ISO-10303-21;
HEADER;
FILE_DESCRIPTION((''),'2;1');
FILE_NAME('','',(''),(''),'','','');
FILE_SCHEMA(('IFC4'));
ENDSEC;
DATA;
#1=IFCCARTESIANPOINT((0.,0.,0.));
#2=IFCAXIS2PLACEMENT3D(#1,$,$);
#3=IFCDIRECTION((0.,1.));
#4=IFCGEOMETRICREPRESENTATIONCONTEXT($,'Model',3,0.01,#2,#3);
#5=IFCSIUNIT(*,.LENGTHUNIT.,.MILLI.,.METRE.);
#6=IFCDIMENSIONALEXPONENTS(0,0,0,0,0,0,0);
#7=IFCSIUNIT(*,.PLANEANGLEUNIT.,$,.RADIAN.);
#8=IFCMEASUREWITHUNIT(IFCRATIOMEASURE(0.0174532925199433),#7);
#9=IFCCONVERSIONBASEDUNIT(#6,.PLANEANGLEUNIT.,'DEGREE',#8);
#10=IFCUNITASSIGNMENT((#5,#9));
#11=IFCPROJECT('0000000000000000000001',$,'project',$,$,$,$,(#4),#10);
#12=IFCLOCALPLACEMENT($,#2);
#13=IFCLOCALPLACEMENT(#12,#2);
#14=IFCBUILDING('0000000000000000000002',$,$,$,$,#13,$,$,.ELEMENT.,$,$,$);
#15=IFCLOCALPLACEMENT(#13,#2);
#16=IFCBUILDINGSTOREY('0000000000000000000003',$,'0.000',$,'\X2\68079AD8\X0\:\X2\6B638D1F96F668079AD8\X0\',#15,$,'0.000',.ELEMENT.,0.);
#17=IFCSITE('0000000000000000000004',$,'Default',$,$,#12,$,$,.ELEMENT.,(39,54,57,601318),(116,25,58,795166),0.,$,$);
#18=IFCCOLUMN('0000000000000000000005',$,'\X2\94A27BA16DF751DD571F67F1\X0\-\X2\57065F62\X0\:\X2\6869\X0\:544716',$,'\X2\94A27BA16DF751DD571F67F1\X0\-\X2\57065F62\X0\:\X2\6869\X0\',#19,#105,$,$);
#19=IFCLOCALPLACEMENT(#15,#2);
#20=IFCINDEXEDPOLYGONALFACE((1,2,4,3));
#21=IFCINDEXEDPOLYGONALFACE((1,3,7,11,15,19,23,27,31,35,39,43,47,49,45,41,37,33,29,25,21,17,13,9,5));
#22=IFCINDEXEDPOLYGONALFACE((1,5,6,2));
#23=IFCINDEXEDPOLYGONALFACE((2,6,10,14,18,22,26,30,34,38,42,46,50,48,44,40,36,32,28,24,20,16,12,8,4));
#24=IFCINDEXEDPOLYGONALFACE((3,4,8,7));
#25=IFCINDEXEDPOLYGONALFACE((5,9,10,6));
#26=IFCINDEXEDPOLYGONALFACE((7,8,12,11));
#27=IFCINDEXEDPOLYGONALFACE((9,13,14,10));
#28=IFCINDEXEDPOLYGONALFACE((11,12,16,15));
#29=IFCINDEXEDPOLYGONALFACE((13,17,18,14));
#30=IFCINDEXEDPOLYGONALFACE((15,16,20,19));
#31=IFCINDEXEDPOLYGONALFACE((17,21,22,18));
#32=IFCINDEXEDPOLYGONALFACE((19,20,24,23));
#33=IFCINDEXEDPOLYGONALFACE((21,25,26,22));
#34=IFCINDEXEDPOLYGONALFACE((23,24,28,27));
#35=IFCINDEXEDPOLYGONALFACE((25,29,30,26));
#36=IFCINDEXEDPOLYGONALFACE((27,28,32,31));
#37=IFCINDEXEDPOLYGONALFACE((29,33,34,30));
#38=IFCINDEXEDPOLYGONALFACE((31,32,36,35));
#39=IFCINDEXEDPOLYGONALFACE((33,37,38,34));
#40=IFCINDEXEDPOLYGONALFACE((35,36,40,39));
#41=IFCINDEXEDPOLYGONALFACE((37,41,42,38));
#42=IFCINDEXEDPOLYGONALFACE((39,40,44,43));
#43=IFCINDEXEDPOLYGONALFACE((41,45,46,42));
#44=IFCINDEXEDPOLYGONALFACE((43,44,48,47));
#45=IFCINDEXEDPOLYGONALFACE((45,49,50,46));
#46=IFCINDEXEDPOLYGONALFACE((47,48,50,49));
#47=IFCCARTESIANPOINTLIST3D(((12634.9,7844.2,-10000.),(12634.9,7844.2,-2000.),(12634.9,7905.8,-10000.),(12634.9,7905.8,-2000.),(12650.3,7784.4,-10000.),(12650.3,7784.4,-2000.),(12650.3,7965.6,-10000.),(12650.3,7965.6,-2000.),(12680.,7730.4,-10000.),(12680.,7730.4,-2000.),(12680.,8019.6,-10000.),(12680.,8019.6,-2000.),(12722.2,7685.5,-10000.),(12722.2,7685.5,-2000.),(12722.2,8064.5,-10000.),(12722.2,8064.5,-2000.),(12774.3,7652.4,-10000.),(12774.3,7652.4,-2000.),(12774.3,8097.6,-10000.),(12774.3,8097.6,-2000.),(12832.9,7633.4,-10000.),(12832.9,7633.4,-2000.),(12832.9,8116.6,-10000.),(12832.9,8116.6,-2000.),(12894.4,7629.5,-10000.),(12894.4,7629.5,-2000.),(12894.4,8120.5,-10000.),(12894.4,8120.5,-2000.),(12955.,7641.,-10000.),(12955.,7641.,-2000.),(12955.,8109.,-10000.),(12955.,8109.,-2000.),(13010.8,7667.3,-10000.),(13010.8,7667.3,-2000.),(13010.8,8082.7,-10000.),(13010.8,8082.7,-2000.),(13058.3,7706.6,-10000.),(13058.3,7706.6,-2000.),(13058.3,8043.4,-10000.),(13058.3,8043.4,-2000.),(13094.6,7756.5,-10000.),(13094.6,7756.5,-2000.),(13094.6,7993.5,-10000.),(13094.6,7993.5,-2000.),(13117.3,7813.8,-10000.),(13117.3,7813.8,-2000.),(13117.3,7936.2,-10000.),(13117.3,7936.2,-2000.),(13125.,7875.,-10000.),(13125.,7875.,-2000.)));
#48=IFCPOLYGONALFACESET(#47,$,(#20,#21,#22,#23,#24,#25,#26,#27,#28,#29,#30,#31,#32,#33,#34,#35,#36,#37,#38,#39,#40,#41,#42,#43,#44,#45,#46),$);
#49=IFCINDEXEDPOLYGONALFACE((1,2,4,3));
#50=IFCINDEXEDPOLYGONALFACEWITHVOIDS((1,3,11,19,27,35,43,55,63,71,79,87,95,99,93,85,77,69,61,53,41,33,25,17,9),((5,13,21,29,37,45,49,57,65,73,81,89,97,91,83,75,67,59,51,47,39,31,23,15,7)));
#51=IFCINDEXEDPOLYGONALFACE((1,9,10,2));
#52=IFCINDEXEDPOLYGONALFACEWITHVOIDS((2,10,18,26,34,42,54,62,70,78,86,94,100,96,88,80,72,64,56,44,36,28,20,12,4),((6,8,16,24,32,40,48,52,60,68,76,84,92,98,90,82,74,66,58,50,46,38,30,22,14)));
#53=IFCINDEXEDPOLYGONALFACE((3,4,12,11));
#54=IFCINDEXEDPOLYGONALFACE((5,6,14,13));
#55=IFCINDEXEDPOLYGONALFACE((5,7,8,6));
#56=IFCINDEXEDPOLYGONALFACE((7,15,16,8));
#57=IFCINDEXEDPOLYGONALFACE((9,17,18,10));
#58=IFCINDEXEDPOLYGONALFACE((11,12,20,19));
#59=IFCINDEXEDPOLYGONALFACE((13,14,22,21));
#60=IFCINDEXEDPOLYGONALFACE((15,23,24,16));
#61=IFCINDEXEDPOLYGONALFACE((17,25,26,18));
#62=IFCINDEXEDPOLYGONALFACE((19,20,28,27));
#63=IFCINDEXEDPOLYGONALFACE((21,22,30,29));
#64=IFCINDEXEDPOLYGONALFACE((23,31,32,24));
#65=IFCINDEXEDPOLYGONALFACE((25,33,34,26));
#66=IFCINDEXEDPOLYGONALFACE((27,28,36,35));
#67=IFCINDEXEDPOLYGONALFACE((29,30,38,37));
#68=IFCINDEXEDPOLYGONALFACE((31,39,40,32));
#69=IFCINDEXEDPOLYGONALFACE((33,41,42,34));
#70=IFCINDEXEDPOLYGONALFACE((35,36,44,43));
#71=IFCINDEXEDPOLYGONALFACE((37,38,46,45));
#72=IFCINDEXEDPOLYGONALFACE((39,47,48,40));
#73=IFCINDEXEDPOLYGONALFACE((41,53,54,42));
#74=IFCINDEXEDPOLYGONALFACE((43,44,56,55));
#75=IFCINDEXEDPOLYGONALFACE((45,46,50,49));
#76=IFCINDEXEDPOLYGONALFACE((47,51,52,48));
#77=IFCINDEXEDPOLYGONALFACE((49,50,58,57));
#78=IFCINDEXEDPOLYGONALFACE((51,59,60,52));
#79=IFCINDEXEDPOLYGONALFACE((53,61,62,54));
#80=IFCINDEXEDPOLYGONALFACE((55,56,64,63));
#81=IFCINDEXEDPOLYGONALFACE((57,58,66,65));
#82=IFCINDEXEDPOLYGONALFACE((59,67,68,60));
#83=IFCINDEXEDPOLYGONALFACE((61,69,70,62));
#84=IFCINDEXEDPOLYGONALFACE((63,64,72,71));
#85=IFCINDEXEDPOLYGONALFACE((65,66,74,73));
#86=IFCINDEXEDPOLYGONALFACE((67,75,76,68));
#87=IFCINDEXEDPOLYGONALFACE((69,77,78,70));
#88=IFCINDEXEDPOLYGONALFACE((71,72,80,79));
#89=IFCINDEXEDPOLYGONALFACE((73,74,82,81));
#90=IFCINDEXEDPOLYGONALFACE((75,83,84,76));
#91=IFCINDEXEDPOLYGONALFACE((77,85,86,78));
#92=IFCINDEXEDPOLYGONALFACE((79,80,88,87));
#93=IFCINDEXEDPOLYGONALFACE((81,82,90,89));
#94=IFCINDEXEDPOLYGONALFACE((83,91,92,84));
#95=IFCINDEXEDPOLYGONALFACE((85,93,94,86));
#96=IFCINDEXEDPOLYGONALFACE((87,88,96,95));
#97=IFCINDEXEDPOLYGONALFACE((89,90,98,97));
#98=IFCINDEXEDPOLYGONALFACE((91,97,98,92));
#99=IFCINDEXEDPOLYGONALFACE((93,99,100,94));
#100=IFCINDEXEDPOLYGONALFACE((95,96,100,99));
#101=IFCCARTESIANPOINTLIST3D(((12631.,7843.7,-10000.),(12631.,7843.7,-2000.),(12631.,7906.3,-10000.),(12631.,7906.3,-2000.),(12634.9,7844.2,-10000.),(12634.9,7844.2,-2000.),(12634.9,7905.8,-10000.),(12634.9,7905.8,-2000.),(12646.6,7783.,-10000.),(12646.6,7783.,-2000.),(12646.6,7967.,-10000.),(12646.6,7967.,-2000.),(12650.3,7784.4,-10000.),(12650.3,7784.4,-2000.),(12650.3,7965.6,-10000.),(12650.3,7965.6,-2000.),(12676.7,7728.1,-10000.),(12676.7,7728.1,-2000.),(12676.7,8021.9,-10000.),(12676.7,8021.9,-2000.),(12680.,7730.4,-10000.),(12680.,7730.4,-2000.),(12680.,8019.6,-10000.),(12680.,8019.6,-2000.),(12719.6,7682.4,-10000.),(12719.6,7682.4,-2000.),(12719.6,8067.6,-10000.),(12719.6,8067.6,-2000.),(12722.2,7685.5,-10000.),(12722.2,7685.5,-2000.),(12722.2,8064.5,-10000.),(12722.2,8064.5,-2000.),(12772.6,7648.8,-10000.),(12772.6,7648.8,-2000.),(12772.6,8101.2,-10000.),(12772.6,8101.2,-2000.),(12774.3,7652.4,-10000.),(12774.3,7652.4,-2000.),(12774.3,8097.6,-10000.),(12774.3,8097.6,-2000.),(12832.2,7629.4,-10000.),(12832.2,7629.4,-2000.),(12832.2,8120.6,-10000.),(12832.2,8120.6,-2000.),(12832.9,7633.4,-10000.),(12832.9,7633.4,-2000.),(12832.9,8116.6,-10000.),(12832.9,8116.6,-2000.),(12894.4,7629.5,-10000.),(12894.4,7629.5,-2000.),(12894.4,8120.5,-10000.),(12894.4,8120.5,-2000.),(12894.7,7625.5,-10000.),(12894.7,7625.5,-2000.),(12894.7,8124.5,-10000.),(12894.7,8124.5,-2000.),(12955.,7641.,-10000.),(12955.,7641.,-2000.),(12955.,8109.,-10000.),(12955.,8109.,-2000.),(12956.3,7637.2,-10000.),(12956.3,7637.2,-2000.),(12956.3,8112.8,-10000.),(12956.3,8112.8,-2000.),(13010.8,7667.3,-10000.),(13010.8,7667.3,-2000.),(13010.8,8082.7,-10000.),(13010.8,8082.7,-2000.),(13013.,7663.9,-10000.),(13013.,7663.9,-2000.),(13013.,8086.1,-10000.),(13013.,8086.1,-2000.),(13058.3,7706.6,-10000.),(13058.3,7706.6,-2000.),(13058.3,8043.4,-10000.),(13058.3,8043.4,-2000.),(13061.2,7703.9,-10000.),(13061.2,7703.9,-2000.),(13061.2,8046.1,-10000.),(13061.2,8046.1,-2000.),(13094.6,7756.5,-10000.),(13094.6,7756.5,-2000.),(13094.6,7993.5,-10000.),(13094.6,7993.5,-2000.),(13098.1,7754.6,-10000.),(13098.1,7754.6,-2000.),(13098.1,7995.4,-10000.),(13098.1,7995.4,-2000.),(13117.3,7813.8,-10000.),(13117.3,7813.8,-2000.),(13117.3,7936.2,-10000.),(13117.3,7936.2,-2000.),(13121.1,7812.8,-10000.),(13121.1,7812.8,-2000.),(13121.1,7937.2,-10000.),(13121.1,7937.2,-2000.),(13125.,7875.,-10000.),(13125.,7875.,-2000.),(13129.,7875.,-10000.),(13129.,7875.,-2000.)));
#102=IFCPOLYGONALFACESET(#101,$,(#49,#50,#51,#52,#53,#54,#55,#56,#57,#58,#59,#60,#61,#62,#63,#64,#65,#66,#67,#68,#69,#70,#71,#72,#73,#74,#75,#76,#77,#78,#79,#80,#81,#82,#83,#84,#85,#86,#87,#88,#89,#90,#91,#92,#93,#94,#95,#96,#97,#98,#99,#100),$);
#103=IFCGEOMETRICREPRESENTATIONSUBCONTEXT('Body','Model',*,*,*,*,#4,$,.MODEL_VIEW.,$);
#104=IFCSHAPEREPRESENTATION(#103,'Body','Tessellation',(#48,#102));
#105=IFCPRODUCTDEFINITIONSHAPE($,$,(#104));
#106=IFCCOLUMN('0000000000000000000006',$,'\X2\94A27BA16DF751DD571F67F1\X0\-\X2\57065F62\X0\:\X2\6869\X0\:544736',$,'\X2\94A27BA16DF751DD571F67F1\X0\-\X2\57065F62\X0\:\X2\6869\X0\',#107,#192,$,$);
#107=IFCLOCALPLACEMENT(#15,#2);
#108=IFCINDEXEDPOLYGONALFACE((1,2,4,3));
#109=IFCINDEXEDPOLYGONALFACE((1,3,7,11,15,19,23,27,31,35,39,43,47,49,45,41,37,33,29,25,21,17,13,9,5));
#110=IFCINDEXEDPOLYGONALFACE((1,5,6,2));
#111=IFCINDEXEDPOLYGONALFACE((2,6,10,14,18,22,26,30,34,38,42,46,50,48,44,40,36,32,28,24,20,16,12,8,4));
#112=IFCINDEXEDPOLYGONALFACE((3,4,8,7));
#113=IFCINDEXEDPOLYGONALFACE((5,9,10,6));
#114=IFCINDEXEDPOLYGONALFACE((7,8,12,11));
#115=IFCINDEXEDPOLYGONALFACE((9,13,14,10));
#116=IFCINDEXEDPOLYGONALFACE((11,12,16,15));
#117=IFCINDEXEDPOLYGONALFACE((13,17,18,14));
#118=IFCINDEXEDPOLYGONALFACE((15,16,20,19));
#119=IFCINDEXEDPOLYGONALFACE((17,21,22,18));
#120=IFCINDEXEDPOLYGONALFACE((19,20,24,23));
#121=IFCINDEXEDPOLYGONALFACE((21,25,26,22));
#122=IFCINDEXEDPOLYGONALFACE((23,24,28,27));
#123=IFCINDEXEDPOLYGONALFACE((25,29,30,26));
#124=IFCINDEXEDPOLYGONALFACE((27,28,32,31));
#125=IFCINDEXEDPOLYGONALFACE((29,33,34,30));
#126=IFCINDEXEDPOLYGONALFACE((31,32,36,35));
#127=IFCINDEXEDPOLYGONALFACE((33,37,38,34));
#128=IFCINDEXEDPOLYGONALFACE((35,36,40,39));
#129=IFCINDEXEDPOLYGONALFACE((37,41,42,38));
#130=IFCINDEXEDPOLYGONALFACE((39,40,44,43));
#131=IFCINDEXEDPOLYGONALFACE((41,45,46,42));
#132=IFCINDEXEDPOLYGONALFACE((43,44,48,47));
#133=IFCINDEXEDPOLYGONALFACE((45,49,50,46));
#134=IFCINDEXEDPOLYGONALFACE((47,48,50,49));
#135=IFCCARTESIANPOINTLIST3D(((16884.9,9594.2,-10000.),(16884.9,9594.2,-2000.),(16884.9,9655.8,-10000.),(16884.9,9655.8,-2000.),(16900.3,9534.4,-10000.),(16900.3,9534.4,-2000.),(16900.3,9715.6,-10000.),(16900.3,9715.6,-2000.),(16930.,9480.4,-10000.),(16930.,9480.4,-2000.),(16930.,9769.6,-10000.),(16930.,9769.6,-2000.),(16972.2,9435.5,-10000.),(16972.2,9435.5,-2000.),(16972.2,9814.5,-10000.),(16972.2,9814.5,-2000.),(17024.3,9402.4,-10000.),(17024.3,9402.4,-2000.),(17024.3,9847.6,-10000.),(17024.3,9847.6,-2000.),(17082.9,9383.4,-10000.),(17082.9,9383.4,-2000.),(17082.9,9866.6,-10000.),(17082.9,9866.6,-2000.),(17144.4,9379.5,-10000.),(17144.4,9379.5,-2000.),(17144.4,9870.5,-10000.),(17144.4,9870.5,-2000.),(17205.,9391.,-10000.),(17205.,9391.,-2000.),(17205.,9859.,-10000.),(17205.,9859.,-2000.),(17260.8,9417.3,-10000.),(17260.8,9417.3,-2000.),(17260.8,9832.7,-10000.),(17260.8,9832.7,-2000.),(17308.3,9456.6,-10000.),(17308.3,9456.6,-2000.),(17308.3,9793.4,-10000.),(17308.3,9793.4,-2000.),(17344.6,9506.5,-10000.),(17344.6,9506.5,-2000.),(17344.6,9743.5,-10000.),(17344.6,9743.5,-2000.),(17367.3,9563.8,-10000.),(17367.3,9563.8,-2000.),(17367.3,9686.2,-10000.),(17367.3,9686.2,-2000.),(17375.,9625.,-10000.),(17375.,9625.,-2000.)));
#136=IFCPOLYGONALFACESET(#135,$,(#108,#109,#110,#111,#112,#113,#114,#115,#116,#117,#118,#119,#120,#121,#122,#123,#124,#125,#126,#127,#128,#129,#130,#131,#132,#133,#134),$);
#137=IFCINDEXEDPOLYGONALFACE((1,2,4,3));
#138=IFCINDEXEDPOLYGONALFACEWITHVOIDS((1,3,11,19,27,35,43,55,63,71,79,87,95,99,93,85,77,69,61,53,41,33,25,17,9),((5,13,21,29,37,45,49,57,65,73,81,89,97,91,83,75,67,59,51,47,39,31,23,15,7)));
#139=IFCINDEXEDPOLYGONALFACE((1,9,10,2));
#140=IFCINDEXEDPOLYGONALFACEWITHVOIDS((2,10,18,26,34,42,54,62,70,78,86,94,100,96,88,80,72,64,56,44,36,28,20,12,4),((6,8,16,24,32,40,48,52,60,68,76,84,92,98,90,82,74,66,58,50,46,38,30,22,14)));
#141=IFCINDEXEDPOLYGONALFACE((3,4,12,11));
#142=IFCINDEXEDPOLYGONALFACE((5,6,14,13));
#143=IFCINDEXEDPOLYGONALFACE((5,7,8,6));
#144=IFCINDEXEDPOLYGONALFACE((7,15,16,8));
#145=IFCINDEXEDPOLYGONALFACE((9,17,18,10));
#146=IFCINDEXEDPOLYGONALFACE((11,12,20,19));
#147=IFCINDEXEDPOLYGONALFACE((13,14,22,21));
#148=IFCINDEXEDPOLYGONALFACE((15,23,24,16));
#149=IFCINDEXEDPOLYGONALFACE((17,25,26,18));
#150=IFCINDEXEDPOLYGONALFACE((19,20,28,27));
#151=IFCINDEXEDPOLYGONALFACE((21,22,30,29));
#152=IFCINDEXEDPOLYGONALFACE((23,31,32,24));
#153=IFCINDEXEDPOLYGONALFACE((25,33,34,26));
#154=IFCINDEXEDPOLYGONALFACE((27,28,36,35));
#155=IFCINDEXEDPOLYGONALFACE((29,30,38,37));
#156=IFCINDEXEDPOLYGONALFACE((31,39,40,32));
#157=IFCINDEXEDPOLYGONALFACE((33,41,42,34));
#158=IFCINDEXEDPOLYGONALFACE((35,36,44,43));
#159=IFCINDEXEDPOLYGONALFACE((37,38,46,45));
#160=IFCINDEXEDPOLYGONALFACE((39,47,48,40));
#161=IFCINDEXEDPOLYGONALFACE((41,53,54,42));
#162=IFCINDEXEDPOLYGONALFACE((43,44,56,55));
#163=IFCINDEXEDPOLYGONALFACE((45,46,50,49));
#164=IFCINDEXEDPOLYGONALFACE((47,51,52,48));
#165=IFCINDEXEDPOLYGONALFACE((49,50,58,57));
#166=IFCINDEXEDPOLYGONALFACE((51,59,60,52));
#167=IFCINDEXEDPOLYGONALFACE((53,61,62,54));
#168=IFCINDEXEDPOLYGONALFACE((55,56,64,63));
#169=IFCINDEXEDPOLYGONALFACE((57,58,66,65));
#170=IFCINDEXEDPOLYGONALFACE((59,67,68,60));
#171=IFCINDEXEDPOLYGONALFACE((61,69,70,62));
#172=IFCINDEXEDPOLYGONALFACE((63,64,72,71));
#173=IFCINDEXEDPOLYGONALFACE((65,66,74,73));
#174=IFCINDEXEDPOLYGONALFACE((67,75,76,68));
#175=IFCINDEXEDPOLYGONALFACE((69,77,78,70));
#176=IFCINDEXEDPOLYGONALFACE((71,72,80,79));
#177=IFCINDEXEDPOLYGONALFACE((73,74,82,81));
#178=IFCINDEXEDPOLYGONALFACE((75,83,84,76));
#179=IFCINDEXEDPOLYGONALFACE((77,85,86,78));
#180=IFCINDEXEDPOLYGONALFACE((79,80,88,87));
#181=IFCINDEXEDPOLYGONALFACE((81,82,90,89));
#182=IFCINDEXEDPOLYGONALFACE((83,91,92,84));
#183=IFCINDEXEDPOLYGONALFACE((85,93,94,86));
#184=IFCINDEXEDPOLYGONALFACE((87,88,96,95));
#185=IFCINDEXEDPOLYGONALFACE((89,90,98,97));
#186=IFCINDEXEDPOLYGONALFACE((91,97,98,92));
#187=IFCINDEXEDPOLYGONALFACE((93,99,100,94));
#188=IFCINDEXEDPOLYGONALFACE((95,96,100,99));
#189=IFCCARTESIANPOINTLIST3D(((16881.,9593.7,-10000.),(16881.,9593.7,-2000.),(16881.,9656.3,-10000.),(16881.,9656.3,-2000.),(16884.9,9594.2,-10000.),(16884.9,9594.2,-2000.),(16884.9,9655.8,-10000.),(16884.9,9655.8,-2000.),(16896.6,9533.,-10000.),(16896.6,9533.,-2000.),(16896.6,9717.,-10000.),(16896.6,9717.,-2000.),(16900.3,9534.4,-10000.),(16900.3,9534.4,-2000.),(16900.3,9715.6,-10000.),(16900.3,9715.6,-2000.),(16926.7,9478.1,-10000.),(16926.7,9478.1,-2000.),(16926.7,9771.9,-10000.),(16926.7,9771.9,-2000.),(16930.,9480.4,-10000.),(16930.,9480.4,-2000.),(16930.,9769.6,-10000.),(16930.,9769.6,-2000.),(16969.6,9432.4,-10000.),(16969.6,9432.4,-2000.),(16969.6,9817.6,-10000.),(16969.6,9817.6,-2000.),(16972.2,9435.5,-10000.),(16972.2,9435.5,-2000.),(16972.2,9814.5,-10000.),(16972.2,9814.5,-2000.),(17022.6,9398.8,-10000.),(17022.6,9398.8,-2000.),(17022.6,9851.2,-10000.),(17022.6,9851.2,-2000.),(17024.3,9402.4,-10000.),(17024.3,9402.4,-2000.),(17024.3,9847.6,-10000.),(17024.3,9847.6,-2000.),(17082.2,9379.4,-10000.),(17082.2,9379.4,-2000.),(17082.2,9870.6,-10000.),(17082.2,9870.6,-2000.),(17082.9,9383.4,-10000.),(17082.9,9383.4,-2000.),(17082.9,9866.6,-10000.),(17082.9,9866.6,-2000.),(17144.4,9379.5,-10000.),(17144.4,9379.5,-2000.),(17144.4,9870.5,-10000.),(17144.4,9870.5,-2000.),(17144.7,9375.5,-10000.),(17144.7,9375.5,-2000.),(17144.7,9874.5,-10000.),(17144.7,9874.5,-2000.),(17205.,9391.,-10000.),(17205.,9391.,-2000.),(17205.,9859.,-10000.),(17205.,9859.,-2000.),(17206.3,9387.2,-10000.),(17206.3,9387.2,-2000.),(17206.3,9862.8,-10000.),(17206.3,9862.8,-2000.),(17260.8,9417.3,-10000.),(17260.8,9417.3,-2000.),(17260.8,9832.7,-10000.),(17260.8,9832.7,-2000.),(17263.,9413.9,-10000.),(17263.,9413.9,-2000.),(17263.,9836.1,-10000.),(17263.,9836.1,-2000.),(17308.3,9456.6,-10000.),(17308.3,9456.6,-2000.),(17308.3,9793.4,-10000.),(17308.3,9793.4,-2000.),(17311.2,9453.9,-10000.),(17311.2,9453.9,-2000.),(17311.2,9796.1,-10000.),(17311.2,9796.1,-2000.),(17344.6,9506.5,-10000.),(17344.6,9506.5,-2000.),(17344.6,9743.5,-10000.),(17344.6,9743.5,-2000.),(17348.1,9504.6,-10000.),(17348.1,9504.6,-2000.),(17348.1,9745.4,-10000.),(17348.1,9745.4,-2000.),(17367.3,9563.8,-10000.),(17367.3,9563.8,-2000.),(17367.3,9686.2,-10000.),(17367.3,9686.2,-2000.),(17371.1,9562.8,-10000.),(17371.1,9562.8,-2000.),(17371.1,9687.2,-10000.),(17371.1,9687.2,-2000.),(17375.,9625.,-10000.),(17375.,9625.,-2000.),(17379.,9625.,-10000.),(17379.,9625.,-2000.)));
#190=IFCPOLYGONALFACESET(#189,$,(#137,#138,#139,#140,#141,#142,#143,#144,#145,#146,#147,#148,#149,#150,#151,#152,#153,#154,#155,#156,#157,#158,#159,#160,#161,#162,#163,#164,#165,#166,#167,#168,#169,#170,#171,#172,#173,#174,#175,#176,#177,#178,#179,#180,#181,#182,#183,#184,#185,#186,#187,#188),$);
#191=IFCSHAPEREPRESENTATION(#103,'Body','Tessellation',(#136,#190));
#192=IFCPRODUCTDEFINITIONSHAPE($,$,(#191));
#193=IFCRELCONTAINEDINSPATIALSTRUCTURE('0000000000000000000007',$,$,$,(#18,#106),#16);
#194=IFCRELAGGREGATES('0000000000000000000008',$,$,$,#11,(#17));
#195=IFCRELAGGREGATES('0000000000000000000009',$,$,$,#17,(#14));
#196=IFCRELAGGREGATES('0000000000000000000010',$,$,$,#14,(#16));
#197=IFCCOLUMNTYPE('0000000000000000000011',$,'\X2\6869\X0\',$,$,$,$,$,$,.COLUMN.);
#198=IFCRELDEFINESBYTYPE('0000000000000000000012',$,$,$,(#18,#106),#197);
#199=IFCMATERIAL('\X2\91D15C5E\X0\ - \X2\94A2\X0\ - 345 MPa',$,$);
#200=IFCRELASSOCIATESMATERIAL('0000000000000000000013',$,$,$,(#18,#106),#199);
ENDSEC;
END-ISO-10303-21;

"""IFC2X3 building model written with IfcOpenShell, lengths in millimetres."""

from ifc_helpers import new_model, entity, si_unit, converted_unit, direction, frame, frame_2d, origin, place, context, subcontext, project, spatial, circle, hollow_circle, extrude, source, transform, mapped, material, type_object, type_shapes, element, save


model = new_model("IFC2X3")

# Units and contexts
model_context = context("Model", 3, precision=0.01, world=origin(), true_north=direction((0.0, 1.0)))
body_context = subcontext(model_context, "Body", "Model", "MODEL_VIEW")
ifc_project = project(units=[si_unit("LENGTHUNIT", "METRE", prefix="MILLI"), converted_unit("PLANEANGLEUNIT", "DEGREE", entity("IfcRatioMeasure", 0.0174532925199433), si_unit("PLANEANGLEUNIT", "RADIAN"), dimensions=[0, 0, 0, 0, 0, 0, 0])], contexts=[model_context])

# Site, building, storey
site_placement = place(None, origin())
site = spatial("IfcSite", under=ifc_project, at=site_placement, Name="Default", CompositionType="ELEMENT", RefLatitude=(39, 54, 57, 601318), RefLongitude=(116, 25, 58, 795166), RefElevation=0.0)
building_placement = place(site_placement, origin())
building = spatial("IfcBuilding", under=site, at=building_placement, CompositionType="ELEMENT")
storey_placement = place(building_placement, origin())
storey = spatial("IfcBuildingStorey", under=building, at=storey_placement, Name="0.000", ObjectType="标高:正负零标高", LongName="0.000", CompositionType="ELEMENT", Elevation=0.0)

# Columns
ifc_material_1 = material(Name="金属 - 钢 - 345 MPa")
column_type = type_object("IfcColumnType", Name="桩", PredefinedType="COLUMN")
shared_shape = source(origin(), body_context, "Body", "SweptSolid", [
    extrude(circle(Radius=246.0, at=frame_2d((0.0, 0.0), x_axis=(1.0, 0.0))), frame((0.0, 0.0, -10000.0)), (0.0, 0.0, 1.0), 8000.0),
    extrude(hollow_circle(Radius=250.0, WallThickness=4.0, at=frame_2d((0.0, 0.0), x_axis=(1.0, 0.0))), frame((0.0, 0.0, -10000.0)), (0.0, 0.0, 1.0), 8000.0),
])
type_shapes(column_type, [shared_shape])
for number, where, name in (
    (1, (12879.0, 7875.0, 0.0), "钢管混凝土柱-圆形:桩:544716"),
    (2, (17129.0, 9625.0, 0.0), "钢管混凝土柱-圆形:桩:544736"),
):
    element("IfcColumn", number, at=place(storey_placement, frame(where)), inside=storey, type_object=column_type, material=ifc_material_1, Name=name, ObjectType="钢管混凝土柱-圆形:桩", context=body_context, shape_type="MappedRepresentation", body=[
        mapped(shared_shape, transform((0.0, 0.0, 0.0), scale=1.0)),
    ])

save(model, "model.ifc")
